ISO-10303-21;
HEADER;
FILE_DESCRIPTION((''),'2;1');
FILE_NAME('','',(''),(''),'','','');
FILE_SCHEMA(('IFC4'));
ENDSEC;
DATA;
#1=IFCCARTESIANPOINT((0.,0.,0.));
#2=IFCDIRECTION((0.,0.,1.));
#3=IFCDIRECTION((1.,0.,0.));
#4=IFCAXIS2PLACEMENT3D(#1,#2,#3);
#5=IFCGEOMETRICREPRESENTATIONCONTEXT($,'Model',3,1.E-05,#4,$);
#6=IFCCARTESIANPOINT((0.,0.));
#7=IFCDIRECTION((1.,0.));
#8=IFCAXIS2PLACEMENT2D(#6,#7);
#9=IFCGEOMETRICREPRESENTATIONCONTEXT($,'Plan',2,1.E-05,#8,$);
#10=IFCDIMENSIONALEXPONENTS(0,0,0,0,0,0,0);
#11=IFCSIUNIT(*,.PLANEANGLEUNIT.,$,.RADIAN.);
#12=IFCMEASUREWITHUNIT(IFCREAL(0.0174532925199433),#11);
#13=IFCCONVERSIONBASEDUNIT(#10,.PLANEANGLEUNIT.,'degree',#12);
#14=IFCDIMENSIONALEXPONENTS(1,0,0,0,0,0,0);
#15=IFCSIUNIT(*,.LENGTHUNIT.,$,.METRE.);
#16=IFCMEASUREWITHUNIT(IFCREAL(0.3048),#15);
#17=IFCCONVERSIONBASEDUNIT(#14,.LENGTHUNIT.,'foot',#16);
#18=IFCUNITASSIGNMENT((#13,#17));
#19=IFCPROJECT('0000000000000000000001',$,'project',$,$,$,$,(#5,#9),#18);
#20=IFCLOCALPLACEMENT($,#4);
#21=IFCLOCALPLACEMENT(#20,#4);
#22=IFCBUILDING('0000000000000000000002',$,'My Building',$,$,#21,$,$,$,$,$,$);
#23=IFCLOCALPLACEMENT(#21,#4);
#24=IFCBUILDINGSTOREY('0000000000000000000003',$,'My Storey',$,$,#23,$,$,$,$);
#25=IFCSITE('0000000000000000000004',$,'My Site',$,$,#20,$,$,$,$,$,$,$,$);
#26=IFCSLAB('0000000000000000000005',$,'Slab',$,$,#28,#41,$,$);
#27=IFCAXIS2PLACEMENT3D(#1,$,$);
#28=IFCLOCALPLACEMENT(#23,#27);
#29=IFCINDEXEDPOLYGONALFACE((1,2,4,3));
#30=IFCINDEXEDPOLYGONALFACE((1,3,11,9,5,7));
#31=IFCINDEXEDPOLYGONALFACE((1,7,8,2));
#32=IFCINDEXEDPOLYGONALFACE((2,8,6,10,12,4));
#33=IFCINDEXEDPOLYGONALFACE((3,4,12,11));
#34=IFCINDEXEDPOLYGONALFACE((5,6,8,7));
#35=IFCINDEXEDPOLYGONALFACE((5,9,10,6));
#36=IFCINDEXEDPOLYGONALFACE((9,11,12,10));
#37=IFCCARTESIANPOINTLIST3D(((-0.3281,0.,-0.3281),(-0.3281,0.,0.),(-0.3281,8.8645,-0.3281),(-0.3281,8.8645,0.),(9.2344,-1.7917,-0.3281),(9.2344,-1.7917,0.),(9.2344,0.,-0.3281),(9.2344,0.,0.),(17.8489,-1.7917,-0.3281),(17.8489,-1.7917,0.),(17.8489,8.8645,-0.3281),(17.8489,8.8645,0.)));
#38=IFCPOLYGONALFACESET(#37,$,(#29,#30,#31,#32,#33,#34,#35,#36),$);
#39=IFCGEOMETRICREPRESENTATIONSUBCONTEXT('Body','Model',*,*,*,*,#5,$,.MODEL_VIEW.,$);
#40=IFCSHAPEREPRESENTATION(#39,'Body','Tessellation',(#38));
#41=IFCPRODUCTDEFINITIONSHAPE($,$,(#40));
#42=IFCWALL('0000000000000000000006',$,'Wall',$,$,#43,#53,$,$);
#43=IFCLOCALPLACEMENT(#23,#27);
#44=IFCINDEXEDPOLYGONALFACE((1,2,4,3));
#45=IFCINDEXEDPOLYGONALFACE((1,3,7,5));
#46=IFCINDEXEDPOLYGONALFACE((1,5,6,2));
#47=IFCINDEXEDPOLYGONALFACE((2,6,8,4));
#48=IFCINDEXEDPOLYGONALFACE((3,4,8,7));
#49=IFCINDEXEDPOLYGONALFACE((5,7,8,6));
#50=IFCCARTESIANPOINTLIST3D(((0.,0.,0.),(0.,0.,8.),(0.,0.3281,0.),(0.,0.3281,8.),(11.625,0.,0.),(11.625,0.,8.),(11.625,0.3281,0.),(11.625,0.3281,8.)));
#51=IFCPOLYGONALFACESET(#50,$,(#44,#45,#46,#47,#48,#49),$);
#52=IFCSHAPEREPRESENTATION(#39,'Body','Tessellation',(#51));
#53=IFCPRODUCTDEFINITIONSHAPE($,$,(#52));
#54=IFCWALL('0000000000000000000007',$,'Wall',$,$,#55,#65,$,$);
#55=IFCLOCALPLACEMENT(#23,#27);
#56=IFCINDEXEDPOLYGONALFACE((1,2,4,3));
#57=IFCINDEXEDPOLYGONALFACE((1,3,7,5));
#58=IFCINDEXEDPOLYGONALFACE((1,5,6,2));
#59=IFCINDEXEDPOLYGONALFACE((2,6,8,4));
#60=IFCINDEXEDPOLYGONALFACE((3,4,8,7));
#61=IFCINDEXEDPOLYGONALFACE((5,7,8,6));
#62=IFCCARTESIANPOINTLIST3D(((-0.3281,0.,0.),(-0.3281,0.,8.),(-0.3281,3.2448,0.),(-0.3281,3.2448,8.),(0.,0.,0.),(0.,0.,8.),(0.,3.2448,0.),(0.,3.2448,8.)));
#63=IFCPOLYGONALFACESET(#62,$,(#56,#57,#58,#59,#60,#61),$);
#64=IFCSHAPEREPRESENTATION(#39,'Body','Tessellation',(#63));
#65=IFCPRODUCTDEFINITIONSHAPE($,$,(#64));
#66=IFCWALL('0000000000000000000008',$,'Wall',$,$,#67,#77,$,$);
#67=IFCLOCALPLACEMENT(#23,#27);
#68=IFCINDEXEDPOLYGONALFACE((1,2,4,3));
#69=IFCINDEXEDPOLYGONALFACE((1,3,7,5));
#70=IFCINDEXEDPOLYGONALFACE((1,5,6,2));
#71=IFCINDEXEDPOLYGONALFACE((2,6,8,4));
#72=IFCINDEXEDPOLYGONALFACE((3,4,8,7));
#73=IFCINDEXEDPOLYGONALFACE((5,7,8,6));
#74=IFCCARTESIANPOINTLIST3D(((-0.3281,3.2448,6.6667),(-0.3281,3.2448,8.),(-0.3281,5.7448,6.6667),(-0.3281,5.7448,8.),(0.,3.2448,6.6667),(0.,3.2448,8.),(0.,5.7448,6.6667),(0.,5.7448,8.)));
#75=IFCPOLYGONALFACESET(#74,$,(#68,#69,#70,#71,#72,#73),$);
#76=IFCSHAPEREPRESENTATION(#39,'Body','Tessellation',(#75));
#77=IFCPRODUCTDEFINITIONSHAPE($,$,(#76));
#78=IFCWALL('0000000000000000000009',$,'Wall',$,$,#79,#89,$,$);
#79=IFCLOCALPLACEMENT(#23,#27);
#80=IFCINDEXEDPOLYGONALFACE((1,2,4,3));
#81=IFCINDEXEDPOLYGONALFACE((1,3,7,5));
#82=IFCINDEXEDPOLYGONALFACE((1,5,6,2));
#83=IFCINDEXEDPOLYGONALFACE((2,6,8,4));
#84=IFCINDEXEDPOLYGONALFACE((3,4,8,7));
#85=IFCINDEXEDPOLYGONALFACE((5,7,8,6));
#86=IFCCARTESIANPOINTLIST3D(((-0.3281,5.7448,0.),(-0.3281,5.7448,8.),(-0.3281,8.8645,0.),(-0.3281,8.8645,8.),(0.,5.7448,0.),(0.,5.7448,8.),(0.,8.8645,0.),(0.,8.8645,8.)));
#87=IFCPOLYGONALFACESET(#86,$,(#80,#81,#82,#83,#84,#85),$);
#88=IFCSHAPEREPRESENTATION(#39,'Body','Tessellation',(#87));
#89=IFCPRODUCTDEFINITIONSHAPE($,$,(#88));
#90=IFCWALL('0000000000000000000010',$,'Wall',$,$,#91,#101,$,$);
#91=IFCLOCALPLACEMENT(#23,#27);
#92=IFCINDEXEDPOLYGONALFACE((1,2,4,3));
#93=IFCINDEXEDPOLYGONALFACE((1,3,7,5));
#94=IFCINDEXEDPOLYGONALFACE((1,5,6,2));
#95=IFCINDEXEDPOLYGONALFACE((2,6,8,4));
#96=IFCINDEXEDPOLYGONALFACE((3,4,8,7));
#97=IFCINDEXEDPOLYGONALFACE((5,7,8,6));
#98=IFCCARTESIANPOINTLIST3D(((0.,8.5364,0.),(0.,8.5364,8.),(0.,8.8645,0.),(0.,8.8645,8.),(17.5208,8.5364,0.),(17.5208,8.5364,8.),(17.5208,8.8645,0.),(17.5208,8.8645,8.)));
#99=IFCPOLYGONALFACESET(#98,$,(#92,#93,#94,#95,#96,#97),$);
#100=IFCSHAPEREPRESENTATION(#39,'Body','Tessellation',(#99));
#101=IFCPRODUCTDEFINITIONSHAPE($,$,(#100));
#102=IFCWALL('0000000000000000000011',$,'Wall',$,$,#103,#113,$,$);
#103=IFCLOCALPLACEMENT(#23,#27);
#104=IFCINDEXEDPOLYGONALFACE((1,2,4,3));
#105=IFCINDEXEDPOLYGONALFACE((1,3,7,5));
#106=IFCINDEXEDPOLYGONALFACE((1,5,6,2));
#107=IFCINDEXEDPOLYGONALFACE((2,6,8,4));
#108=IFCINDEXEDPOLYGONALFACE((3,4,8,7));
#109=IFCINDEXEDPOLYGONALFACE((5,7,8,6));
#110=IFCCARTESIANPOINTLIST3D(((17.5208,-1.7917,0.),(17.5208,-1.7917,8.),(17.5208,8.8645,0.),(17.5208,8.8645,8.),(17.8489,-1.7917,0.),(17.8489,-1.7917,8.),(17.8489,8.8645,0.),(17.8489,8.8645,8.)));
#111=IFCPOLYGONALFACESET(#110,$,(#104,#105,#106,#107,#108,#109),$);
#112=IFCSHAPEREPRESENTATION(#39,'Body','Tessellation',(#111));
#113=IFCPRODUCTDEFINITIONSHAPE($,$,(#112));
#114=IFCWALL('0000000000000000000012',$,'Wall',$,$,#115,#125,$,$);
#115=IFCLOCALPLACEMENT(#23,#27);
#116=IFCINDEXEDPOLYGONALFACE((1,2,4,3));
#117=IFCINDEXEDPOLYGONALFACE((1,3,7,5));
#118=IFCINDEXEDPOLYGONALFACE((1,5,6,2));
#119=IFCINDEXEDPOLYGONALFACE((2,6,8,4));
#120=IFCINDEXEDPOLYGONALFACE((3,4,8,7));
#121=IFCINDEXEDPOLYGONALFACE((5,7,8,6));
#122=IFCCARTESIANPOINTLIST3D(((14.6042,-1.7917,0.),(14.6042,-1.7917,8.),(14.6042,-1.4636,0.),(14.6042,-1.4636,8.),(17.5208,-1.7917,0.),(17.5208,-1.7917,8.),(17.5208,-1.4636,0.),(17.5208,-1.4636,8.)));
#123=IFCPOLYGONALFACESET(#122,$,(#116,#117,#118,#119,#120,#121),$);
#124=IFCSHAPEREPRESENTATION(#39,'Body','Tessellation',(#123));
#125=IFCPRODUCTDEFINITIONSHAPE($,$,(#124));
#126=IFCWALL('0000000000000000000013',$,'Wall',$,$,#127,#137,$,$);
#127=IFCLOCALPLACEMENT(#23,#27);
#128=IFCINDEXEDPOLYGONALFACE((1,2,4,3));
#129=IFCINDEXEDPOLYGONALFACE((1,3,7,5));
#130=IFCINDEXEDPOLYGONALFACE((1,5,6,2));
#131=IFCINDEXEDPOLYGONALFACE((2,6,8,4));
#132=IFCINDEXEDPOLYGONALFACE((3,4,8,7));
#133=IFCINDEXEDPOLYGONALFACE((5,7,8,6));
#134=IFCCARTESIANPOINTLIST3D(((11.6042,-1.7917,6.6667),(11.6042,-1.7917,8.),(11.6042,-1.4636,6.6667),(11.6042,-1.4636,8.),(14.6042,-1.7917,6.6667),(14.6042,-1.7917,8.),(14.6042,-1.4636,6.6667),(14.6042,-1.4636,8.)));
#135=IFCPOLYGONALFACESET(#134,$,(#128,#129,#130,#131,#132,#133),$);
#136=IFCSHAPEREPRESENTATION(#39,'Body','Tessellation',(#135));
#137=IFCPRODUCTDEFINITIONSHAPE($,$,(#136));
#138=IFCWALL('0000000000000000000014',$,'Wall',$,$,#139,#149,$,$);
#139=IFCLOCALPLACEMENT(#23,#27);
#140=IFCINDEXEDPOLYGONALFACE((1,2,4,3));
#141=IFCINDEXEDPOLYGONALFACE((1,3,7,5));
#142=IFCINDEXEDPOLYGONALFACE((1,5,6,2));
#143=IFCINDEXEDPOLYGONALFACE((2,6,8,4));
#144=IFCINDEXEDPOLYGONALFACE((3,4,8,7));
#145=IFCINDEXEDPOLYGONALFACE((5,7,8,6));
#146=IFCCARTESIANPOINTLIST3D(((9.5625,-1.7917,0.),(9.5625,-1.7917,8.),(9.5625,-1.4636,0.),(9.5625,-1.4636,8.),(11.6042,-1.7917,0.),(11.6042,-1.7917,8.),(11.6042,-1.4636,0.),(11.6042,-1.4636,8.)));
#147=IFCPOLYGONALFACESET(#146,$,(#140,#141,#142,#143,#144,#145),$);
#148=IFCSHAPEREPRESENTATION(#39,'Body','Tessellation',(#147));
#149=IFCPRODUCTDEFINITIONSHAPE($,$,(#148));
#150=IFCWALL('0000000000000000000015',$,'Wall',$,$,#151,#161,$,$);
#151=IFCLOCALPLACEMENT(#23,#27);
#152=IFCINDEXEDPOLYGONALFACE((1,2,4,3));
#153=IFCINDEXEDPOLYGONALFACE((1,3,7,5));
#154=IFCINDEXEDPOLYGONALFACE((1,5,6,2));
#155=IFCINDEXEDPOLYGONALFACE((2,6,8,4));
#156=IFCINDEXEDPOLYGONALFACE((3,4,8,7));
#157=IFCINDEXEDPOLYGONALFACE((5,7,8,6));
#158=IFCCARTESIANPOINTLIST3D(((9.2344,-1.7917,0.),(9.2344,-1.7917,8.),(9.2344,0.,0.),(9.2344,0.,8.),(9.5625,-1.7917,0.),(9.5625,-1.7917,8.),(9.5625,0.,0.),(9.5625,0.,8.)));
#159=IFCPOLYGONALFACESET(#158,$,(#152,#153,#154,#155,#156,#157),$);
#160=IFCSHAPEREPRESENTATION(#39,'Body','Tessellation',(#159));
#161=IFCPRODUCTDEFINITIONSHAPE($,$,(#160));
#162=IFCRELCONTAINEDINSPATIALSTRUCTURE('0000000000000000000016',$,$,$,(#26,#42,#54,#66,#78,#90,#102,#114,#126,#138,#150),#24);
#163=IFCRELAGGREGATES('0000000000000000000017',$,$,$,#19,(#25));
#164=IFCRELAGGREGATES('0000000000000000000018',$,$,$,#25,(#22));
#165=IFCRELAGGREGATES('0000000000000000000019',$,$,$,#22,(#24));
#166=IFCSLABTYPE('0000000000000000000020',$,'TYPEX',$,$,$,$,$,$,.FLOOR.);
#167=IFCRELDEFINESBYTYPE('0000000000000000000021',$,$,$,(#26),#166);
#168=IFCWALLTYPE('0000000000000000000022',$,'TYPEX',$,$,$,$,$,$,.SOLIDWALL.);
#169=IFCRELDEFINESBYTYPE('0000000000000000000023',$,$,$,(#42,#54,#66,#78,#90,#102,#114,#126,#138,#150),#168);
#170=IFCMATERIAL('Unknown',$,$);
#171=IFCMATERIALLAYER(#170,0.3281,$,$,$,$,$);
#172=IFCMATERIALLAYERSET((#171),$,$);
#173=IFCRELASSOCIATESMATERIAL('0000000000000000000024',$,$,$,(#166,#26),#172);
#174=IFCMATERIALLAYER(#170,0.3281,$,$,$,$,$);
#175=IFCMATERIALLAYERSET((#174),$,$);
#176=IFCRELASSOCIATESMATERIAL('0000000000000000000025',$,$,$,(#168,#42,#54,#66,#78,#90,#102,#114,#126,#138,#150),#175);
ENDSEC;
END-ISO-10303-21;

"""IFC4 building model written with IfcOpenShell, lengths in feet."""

from ifc_helpers import new_model, entity, si_unit, converted_unit, frame, origin_with_axes, origin_2d_with_axis, place, context, subcontext, project, spatial, line, indexed_curve, outline, extrude, material, layer, layer_set, layer_usage, type_object, element, save


model = new_model("IFC4")

# Units and contexts
model_context = context("Model", 3, precision=1e-05, world=origin_with_axes())
plan_context = context("Plan", 2, precision=1e-05, world=origin_2d_with_axis())
body_context_1 = subcontext(model_context, "Body", "Model", "MODEL_VIEW")
ifc_project = project(units=[converted_unit("PLANEANGLEUNIT", "degree", entity("IfcReal", 0.0174532925199433), si_unit("PLANEANGLEUNIT", "RADIAN"), dimensions=[0, 0, 0, 0, 0, 0, 0]), converted_unit("LENGTHUNIT", "foot", entity("IfcReal", 0.3048), si_unit("LENGTHUNIT", "METRE"), dimensions=[1, 0, 0, 0, 0, 0, 0])], contexts=[model_context, plan_context])

# Site, building, storey
site_placement = place(None, origin_with_axes())
site = spatial("IfcSite", under=ifc_project, at=site_placement, Name="My Site")
building_placement = place(site_placement, origin_with_axes())
building = spatial("IfcBuilding", under=site, at=building_placement, Name="My Building")
storey_placement = place(building_placement, origin_with_axes())
storey = spatial("IfcBuildingStorey", under=building, at=storey_placement, Name="My Storey")

# Slab
ifc_material = material(Name="Unknown")
ifc_layer_1 = layer(ifc_material, 0.3281)
ifc_layer_set_1 = layer_set([ifc_layer_1])
ifc_layer_usage_1 = layer_usage(ifc_layer_set_1, "AXIS3", "POSITIVE", 0.0)
slab_type = type_object("IfcSlabType", Name="TYPEX", PredefinedType="FLOOR", material=ifc_layer_set_1)
slab_placement = place(storey_placement, frame((-0.3281, 0.0, -0.3281), z_axis=(0.0, 0.0, 1.0), x_axis=(1.0, 0.0, 0.0)))
element("IfcSlab", 1, at=slab_placement, inside=storey, type_object=slab_type, material=ifc_layer_usage_1, Name="Slab", context=body_context_1, shape_type="SweptSolid", body=[
    extrude(outline(indexed_curve([(0.0, 0.0), (9.5625, 0.0), (18.177, 8.8645), (0.0, 8.8645), (18.177, -1.7917), (9.5625, -1.7917)], segments=[line(5, 3), line(3, 4), line(4, 1), line(1, 2), line(2, 6), line(6, 5)], self_intersect=False)), None, (0.0, 0.0, 1.0), 0.3281),
])

# Walls
ifc_layer_2 = layer(ifc_material, 0.3281)
ifc_layer_set_2 = layer_set([ifc_layer_2])
ifc_layer_usage_2 = layer_usage(ifc_layer_set_2, "AXIS2", "POSITIVE", 0.0)
wall_type = type_object("IfcWallType", Name="TYPEX", PredefinedType="SOLIDWALL", material=ifc_layer_set_2)
wall_1_placement = place(storey_placement, origin_with_axes())
element("IfcWall", 2, at=wall_1_placement, inside=storey, type_object=wall_type, material=ifc_layer_usage_2, Name="Wall", context=body_context_1, shape_type="SweptSolid", body=[
    extrude(outline(indexed_curve([(0.0, 0.0), (0.0, 0.3281), (11.625, 0.3281), (11.625, 0.0), (0.0, 0.0)], self_intersect=False)), origin_with_axes(), (0.0, 0.0, 1.0), 8.0),
])
ifc_layer_usage_3 = layer_usage(ifc_layer_set_2, "AXIS2", "POSITIVE", 0.0)
wall_2_placement = place(storey_placement, frame((0.0, 0.0, 0.0), z_axis=(0.0, 0.0, 1.0), x_axis=(0.000001, 1.0, 0.0)))
element("IfcWall", 3, at=wall_2_placement, inside=storey, type_object=wall_type, material=ifc_layer_usage_3, Name="Wall", context=body_context_1, shape_type="SweptSolid", body=[
    extrude(outline(indexed_curve([(0.0, 0.0), (0.0, 0.3281), (3.2448, 0.3281), (3.2448, 0.0), (0.0, 0.0)], self_intersect=False)), origin_with_axes(), (0.0, 0.0, 1.0), 8.0),
])
ifc_layer_usage_4 = layer_usage(ifc_layer_set_2, "AXIS2", "POSITIVE", 0.0)
wall_3_placement = place(storey_placement, frame((-0.3281, 5.7448, 6.6667), z_axis=(0.0, 0.0, 1.0), x_axis=(-0.000001, -1.0, 0.0)))
element("IfcWall", 4, at=wall_3_placement, inside=storey, type_object=wall_type, material=ifc_layer_usage_4, Name="Wall", context=body_context_1, shape_type="SweptSolid", body=[
    extrude(outline(indexed_curve([(0.0, 0.0), (0.0, 0.3281), (2.5, 0.3281), (2.5, 0.0), (0.0, 0.0)], self_intersect=False)), origin_with_axes(), (0.0, 0.0, 1.0), 1.3333),
])
ifc_layer_usage_5 = layer_usage(ifc_layer_set_2, "AXIS2", "POSITIVE", 0.0)
wall_4_placement = place(storey_placement, frame((-0.3281, 8.8645, 0.0), z_axis=(0.0, 0.0, 1.0), x_axis=(-0.000001, -1.0, 0.0)))
element("IfcWall", 5, at=wall_4_placement, inside=storey, type_object=wall_type, material=ifc_layer_usage_5, Name="Wall", context=body_context_1, shape_type="SweptSolid", body=[
    extrude(outline(indexed_curve([(0.0, 0.0), (0.0, 0.3281), (3.1198, 0.3281), (3.1198, 0.0), (0.0, 0.0)], self_intersect=False)), origin_with_axes(), (0.0, 0.0, 1.0), 8.0),
])
ifc_layer_usage_6 = layer_usage(ifc_layer_set_2, "AXIS2", "POSITIVE", 0.0)
wall_5_placement = place(storey_placement, frame((0.0, 8.5364, 0.0), z_axis=(0.0, 0.0, 1.0), x_axis=(1.0, -0.000001, 0.0)))
element("IfcWall", 6, at=wall_5_placement, inside=storey, type_object=wall_type, material=ifc_layer_usage_6, Name="Wall", context=body_context_1, shape_type="SweptSolid", body=[
    extrude(outline(indexed_curve([(0.0, 0.0), (0.0, 0.3281), (17.5208, 0.3281), (17.5208, 0.0), (0.0, 0.0)], self_intersect=False)), origin_with_axes(), (0.0, 0.0, 1.0), 8.0),
])
ifc_layer_usage_7 = layer_usage(ifc_layer_set_2, "AXIS2", "POSITIVE", 0.0)
wall_6_placement = place(storey_placement, frame((17.5208, 8.8645, 0.0), z_axis=(0.0, 0.0, 1.0), x_axis=(-0.000001, -1.0, 0.0)))
element("IfcWall", 7, at=wall_6_placement, inside=storey, type_object=wall_type, material=ifc_layer_usage_7, Name="Wall", context=body_context_1, shape_type="SweptSolid", body=[
    extrude(outline(indexed_curve([(0.0, 0.0), (0.0, 0.3281), (10.6562, 0.3281), (10.6562, 0.0), (0.0, 0.0)], self_intersect=False)), origin_with_axes(), (0.0, 0.0, 1.0), 8.0),
])
ifc_layer_usage_8 = layer_usage(ifc_layer_set_2, "AXIS2", "POSITIVE", 0.0)
wall_7_placement = place(storey_placement, frame((17.5208, -1.4636, 0.0), z_axis=(0.0, 0.0, 1.0), x_axis=(-1.0, 0.000002, 0.0)))
element("IfcWall", 8, at=wall_7_placement, inside=storey, type_object=wall_type, material=ifc_layer_usage_8, Name="Wall", context=body_context_1, shape_type="SweptSolid", body=[
    extrude(outline(indexed_curve([(0.0, 0.0), (0.0, 0.3281), (2.9167, 0.3281), (2.9167, 0.0), (0.0, 0.0)], self_intersect=False)), origin_with_axes(), (0.0, 0.0, 1.0), 8.0),
])
ifc_layer_usage_9 = layer_usage(ifc_layer_set_2, "AXIS2", "POSITIVE", 0.0)
wall_8_placement = place(storey_placement, frame((11.6042, -1.7917, 6.6667), z_axis=(0.0, 0.0, 1.0), x_axis=(1.0, -0.000002, 0.0)))
element("IfcWall", 9, at=wall_8_placement, inside=storey, type_object=wall_type, material=ifc_layer_usage_9, Name="Wall", context=body_context_1, shape_type="SweptSolid", body=[
    extrude(outline(indexed_curve([(0.0, 0.0), (0.0, 0.3281), (3.0, 0.3281), (3.0, 0.0), (0.0, 0.0)], self_intersect=False)), origin_with_axes(), (0.0, 0.0, 1.0), 1.3333),
])
ifc_layer_usage_10 = layer_usage(ifc_layer_set_2, "AXIS2", "POSITIVE", 0.0)
wall_9_placement = place(storey_placement, frame((9.5625, -1.7917, 0.0), z_axis=(0.0, 0.0, 1.0), x_axis=(1.0, -0.000002, 0.0)))
element("IfcWall", 10, at=wall_9_placement, inside=storey, type_object=wall_type, material=ifc_layer_usage_10, Name="Wall", context=body_context_1, shape_type="SweptSolid", body=[
    extrude(outline(indexed_curve([(0.0, 0.0), (0.0, 0.3281), (2.0417, 0.3281), (2.0417, 0.0), (0.0, 0.0)], self_intersect=False)), origin_with_axes(), (0.0, 0.0, 1.0), 8.0),
])
ifc_layer_usage_11 = layer_usage(ifc_layer_set_2, "AXIS2", "POSITIVE", 0.0)
wall_10_placement = place(storey_placement, frame((9.5625, -1.7917, 0.0), z_axis=(0.0, 0.0, 1.0), x_axis=(0.000003, 1.0, 0.0)))
element("IfcWall", 11, at=wall_10_placement, inside=storey, type_object=wall_type, material=ifc_layer_usage_11, Name="Wall", context=body_context_1, shape_type="SweptSolid", body=[
    extrude(outline(indexed_curve([(0.0, 0.0), (0.0, 0.3281), (1.7917, 0.3281), (1.7917, 0.0), (0.0, 0.0)], self_intersect=False)), origin_with_axes(), (0.0, 0.0, 1.0), 8.0),
])

save(model, "model.ifc")
